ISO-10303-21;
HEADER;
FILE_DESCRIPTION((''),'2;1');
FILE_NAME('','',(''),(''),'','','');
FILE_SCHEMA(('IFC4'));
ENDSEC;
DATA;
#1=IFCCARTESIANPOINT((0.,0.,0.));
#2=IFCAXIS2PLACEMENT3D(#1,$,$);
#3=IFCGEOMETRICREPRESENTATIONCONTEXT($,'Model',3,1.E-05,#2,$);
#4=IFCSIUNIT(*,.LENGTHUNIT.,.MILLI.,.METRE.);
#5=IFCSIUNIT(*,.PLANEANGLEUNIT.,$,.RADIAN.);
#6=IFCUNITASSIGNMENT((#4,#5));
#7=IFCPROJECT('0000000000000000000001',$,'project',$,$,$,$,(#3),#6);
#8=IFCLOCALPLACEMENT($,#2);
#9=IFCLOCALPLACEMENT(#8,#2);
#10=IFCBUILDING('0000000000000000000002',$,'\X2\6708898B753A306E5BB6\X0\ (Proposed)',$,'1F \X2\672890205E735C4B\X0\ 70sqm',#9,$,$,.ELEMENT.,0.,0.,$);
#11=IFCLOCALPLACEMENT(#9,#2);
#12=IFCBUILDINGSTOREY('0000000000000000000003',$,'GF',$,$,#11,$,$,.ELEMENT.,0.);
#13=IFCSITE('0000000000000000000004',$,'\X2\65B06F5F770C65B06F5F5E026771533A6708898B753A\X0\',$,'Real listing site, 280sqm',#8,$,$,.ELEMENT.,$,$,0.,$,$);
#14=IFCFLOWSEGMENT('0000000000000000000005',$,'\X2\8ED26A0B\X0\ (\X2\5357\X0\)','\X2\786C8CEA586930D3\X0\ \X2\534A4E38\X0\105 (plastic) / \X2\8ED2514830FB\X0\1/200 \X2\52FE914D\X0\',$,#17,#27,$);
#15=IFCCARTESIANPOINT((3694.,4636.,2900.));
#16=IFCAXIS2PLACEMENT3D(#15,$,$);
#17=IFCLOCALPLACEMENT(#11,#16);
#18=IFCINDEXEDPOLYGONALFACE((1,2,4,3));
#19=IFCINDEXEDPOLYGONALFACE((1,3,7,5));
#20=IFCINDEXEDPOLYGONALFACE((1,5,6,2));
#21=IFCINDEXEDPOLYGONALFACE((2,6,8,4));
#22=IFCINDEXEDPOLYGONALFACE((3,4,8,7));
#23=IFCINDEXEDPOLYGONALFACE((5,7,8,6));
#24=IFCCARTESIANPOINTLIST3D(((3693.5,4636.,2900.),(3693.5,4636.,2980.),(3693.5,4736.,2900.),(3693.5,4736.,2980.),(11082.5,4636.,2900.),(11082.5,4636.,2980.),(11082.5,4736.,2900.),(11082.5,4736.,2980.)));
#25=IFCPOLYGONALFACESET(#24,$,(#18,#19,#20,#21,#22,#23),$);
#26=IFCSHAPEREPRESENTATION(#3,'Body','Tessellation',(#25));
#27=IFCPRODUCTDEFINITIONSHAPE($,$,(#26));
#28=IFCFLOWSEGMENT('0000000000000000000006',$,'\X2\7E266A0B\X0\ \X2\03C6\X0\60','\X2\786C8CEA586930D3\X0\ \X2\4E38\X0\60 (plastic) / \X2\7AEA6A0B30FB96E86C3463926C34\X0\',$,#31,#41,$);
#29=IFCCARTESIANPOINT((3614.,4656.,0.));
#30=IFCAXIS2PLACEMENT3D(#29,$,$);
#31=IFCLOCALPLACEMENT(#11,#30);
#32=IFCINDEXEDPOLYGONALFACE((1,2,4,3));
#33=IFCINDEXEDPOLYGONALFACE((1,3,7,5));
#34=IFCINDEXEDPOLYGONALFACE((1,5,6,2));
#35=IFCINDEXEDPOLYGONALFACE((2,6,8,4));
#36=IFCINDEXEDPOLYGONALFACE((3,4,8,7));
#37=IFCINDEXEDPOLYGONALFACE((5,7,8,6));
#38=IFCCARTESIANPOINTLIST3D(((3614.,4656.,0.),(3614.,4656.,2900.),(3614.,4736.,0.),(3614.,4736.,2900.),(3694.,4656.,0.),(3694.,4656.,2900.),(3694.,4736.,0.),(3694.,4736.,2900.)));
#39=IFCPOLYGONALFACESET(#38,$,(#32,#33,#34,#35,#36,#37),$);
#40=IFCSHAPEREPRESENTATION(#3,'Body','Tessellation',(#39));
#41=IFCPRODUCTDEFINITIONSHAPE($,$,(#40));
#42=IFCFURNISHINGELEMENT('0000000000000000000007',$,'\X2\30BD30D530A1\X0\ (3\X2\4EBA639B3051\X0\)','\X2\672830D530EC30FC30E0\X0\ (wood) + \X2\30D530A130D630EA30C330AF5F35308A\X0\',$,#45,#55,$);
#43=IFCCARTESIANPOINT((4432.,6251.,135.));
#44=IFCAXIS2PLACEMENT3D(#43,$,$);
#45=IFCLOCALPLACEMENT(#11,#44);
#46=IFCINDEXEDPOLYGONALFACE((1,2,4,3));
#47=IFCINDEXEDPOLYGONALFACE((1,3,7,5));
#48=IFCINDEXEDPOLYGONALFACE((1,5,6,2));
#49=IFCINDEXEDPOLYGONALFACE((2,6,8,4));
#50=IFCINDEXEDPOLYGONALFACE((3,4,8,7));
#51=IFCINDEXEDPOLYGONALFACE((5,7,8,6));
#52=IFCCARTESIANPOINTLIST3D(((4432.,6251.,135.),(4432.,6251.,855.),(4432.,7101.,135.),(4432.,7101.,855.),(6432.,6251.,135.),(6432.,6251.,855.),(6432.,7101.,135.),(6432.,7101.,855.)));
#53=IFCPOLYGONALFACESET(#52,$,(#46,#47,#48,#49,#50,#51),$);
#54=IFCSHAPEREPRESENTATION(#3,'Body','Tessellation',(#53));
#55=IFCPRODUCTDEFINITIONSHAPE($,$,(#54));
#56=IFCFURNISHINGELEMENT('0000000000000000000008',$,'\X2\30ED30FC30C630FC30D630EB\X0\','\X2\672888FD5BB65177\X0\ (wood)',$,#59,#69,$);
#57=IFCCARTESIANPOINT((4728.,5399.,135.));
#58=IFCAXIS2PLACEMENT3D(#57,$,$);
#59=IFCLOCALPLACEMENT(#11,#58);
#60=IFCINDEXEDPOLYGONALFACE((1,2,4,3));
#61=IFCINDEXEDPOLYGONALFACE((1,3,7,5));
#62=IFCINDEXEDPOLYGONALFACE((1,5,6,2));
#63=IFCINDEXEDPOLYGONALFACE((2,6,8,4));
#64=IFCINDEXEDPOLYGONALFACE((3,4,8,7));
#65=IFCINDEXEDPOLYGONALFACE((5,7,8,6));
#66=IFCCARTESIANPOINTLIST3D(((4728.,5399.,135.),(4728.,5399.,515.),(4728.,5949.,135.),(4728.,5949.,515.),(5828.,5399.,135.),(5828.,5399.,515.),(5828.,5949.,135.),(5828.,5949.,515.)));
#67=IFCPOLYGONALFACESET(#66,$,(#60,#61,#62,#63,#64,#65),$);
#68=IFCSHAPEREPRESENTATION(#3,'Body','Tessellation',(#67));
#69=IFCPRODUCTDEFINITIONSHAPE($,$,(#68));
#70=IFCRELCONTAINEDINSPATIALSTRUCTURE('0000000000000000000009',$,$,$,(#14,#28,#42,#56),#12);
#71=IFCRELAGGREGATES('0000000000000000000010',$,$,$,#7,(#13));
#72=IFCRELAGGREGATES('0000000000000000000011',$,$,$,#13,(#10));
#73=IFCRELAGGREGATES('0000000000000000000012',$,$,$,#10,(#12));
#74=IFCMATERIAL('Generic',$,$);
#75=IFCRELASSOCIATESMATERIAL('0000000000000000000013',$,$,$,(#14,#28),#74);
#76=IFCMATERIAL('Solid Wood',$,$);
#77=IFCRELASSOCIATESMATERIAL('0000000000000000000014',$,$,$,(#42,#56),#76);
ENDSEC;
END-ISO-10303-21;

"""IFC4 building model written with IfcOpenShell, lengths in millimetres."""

from ifc_helpers import new_model, si_unit, frame, frame_2d, origin, place, context, project, spatial, rectangle, extrude, material, element, save


model = new_model("IFC4")

# Units and contexts
model_context = context("Model", 3, precision=1e-05, world=origin())
ifc_project = project(units=[si_unit("LENGTHUNIT", "METRE", prefix="MILLI"), si_unit("PLANEANGLEUNIT", "RADIAN")], contexts=[model_context])

# Site, building, storey
site_placement = place(None, origin())
site = spatial("IfcSite", under=ifc_project, at=site_placement, Name="新潟県新潟市東区月見町", ObjectType="Real listing site, 280sqm", CompositionType="ELEMENT", RefElevation=0.0)
building_placement = place(site_placement, origin())
building = spatial("IfcBuilding", under=site, at=building_placement, Name="月見町の家 (Proposed)", ObjectType="1F 木造平屋 70sqm", CompositionType="ELEMENT", ElevationOfRefHeight=0.0, ElevationOfTerrain=0.0)
storey_placement = place(building_placement, origin())
storey = spatial("IfcBuildingStorey", under=building, at=storey_placement, Name="GF", CompositionType="ELEMENT", Elevation=0.0)

# Shared definitions
ifc_material_1 = material(Name="Solid Wood")

# Shared definitions
ifc_material_2 = material(Name="Generic")

# Flow segments
flow_segment_1_placement = place(storey_placement, frame((3694.0, 4636.0, 2900.0)))
element("IfcFlowSegment", 1, at=flow_segment_1_placement, inside=storey, material=ifc_material_2, Name="軒樋 (南)", Description="硬質塩ビ 半丸105 (plastic) / 軒先・1/200 勾配", context=model_context, shape_type="SweptSolid", body=[
    extrude(rectangle(XDim=7389.0, YDim=100.0, at=frame_2d((3694.0, 50.0))), frame((3694.0, 4636.0, 2900.0)), (0.0, 0.0, 1.0), 80.0),
])
flow_segment_2_placement = place(storey_placement, frame((3614.0, 4656.0, 0.0)))
element("IfcFlowSegment", 2, at=flow_segment_2_placement, inside=storey, material=ifc_material_2, Name="縦樋 φ60", Description="硬質塩ビ 丸60 (plastic) / 竪樋・雨水排水", context=model_context, shape_type="SweptSolid", body=[
    extrude(rectangle(XDim=80.0, YDim=80.0, at=frame_2d((40.0, 40.0))), frame((3614.0, 4656.0, 0.0)), (0.0, 0.0, 1.0), 2900.0),
])

# Furnishing elements
furnishing_1_placement = place(storey_placement, frame((4432.0, 6251.0, 135.0)))
element("IfcFurnishingElement", 3, at=furnishing_1_placement, inside=storey, material=ifc_material_1, Name="ソファ (3人掛け)", Description="木フレーム (wood) + ファブリック張り", context=model_context, shape_type="SweptSolid", body=[
    extrude(rectangle(XDim=2000.0, YDim=850.0, at=frame_2d((1000.0, 425.0))), frame((4432.0, 6251.0, 135.0)), (0.0, 0.0, 1.0), 720.0),
])
furnishing_2_placement = place(storey_placement, frame((4728.0, 5399.0, 135.0)))
element("IfcFurnishingElement", 4, at=furnishing_2_placement, inside=storey, material=ifc_material_1, Name="ローテーブル", Description="木製家具 (wood)", context=model_context, shape_type="SweptSolid", body=[
    extrude(rectangle(XDim=1100.0, YDim=550.0, at=frame_2d((550.0, 275.0))), frame((4728.0, 5399.0, 135.0)), (0.0, 0.0, 1.0), 380.0),
])

save(model, "model.ifc")
